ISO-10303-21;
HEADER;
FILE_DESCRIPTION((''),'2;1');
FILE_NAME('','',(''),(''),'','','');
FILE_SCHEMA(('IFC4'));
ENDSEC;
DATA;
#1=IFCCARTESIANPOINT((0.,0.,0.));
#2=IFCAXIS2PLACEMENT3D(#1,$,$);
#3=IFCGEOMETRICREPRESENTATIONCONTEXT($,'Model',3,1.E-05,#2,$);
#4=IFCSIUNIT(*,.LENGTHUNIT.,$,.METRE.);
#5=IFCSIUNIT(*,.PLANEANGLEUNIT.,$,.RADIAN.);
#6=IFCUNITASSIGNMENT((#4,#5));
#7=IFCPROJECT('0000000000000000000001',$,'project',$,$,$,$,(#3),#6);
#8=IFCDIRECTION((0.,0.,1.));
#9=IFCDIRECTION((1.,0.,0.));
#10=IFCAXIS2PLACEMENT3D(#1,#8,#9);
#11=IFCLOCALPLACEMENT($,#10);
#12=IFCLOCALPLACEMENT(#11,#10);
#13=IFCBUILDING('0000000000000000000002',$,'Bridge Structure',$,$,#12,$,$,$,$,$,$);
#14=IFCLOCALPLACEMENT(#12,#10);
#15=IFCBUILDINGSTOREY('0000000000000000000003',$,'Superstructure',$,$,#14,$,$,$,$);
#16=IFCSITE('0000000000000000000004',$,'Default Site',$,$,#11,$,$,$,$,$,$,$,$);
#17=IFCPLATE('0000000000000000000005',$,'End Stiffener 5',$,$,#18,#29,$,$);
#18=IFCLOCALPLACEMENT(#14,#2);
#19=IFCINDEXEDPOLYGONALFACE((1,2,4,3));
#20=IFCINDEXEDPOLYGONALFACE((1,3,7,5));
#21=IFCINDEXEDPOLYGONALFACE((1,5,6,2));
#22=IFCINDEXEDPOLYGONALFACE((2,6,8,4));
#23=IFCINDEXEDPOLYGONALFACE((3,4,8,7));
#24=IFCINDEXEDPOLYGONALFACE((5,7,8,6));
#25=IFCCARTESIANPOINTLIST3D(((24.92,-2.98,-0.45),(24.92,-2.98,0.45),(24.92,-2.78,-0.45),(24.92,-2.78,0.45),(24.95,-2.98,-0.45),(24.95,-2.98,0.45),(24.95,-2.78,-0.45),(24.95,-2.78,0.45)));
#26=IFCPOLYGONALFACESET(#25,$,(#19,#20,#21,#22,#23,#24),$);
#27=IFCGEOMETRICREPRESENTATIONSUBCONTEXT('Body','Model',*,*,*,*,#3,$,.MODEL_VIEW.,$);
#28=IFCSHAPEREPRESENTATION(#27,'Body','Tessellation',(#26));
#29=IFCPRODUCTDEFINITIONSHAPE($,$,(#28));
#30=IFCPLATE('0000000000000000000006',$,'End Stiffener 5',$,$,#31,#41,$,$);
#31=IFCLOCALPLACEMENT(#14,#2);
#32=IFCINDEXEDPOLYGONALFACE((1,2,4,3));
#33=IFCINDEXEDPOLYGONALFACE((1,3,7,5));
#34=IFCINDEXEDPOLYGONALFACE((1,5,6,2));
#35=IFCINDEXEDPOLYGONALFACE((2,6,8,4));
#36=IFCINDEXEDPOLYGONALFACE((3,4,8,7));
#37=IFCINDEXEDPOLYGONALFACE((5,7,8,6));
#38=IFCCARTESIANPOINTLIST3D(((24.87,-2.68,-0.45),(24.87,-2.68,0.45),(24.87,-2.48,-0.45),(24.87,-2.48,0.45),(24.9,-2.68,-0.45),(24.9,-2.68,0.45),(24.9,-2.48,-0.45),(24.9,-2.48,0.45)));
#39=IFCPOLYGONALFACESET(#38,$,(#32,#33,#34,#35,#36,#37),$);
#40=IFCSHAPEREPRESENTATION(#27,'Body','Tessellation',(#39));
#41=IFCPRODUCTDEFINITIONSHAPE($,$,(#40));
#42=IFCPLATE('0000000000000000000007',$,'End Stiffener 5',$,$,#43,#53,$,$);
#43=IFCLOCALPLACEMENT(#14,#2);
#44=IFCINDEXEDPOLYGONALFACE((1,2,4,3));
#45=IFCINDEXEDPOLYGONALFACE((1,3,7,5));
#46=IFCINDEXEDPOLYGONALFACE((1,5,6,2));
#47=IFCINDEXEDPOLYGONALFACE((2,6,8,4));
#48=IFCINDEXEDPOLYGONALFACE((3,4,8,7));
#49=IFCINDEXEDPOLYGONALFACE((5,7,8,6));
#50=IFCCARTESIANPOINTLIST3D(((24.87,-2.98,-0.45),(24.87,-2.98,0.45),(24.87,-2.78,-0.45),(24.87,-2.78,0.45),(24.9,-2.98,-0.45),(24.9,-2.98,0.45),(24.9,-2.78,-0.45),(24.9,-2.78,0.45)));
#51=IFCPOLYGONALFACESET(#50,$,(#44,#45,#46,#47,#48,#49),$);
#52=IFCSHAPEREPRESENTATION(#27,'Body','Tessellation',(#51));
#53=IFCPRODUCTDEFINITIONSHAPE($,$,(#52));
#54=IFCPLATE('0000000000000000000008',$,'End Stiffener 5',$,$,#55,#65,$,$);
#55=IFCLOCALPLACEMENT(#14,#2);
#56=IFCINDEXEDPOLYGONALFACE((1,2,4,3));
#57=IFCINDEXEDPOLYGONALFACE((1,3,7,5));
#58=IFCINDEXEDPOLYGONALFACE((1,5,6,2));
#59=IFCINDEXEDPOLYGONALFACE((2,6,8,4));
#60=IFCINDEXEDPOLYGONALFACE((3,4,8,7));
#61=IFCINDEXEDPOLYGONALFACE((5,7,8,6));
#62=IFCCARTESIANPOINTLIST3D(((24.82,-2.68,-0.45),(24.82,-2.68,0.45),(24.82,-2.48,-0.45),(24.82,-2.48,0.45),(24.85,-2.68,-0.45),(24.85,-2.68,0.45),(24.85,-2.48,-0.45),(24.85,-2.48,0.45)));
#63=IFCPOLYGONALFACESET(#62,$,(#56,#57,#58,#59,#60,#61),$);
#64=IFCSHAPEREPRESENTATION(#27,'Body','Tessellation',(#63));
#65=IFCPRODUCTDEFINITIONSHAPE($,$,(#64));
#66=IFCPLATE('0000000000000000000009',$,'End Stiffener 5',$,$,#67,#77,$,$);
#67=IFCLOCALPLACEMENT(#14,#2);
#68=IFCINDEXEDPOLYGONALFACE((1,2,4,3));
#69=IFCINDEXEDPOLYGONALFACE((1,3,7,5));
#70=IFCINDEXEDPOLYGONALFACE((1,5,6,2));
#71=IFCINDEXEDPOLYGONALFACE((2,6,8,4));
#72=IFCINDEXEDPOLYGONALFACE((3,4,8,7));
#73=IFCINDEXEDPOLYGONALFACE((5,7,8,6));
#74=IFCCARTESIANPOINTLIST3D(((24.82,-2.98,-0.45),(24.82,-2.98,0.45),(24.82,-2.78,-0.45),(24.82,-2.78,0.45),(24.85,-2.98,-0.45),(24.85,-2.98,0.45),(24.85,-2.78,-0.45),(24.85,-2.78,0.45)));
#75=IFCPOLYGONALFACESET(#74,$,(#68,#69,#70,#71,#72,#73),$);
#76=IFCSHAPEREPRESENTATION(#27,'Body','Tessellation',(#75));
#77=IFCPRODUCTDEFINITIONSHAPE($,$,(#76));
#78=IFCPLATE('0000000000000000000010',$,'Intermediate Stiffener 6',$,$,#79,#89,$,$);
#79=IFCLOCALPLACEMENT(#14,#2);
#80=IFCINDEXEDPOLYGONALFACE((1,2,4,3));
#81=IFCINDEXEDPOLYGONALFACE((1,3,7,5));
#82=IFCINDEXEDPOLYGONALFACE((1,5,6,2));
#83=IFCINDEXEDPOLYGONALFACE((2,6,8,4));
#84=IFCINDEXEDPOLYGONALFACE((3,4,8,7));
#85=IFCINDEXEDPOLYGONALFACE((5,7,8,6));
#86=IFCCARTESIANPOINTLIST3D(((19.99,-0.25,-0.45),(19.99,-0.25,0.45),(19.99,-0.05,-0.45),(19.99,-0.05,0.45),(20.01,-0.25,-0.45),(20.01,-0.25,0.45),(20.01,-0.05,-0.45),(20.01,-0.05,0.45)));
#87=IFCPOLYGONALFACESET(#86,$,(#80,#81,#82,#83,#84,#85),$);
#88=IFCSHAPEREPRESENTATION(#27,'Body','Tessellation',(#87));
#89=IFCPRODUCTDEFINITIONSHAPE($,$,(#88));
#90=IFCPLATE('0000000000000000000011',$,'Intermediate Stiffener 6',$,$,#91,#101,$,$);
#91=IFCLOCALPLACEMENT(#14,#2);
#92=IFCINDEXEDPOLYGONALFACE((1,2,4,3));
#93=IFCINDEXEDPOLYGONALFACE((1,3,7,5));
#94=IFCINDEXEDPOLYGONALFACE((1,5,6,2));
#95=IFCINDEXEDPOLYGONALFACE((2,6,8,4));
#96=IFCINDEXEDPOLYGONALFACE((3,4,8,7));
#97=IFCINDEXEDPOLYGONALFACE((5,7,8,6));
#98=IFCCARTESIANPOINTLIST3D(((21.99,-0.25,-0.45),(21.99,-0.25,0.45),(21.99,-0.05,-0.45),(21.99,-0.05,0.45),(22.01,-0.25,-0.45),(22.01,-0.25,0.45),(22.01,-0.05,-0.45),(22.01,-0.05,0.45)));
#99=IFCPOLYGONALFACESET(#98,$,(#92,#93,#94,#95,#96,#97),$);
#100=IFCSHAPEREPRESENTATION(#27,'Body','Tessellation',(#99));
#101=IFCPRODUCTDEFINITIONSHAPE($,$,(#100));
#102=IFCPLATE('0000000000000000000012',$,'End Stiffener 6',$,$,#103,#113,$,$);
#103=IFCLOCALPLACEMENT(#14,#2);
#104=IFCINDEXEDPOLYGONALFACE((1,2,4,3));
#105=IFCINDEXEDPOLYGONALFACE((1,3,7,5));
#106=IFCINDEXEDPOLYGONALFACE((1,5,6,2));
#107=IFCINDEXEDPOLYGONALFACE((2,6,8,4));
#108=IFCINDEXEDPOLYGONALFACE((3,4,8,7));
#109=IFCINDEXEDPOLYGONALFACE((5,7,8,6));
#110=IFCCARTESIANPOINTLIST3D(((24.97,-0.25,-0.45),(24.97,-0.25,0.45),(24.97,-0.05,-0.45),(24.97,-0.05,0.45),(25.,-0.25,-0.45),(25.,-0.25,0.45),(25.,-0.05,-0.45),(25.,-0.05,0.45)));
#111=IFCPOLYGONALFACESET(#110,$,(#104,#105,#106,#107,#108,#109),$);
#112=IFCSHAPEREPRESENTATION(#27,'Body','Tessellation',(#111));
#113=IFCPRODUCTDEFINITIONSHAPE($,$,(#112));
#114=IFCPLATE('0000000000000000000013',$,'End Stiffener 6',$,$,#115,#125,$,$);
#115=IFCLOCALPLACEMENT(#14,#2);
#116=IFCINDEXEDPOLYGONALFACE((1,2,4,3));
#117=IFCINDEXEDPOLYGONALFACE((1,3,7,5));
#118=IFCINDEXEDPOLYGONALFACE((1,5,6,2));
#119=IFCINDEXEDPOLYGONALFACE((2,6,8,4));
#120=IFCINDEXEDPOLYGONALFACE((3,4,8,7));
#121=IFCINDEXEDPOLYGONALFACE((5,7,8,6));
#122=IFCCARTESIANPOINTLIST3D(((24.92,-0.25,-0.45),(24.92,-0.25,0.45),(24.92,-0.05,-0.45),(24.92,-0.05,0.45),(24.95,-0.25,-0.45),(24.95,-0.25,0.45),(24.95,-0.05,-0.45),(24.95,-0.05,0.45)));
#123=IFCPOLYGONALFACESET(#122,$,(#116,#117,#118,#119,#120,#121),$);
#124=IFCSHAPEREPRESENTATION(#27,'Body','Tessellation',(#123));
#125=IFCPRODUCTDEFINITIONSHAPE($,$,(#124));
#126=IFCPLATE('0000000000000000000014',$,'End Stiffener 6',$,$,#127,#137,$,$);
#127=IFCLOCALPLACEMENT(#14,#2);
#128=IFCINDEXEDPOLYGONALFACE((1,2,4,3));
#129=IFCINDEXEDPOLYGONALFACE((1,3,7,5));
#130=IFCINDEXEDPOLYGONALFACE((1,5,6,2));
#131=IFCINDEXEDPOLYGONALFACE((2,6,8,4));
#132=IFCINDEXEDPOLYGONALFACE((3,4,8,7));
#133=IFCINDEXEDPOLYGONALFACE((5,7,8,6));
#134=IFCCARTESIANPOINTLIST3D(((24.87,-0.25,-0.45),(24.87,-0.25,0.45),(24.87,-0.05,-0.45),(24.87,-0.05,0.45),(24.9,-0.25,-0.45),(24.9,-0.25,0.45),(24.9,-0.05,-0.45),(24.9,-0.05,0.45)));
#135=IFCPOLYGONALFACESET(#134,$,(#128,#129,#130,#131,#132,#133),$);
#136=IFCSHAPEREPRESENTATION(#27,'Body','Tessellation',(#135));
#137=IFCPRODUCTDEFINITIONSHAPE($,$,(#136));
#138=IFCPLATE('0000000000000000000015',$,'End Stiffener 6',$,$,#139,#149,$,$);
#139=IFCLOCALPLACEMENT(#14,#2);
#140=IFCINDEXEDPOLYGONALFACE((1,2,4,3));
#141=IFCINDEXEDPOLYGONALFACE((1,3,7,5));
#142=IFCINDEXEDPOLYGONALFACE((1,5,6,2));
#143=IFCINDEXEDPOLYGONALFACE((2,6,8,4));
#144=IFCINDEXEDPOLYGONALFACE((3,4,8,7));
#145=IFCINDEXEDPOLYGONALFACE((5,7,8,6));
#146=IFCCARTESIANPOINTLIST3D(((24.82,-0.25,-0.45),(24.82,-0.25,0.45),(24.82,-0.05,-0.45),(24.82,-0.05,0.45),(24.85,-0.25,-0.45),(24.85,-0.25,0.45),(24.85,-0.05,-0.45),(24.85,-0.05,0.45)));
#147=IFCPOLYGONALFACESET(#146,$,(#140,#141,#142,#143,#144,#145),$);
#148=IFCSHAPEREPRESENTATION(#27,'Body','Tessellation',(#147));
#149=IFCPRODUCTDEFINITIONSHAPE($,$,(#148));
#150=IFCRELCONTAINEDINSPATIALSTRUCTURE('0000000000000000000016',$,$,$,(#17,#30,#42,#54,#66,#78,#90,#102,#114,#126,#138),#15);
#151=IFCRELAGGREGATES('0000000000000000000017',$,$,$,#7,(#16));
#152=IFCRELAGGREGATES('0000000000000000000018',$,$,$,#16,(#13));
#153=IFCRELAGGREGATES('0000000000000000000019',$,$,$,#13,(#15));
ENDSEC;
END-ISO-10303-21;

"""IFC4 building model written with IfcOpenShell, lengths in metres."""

from ifc_helpers import new_model, si_unit, frame, origin, origin_with_axes, origin_2d_with_axis, place, context, subcontext, project, spatial, rectangle, extrude, element, save


model = new_model("IFC4")

# Units and contexts
model_context = context("Model", 3, precision=1e-05, world=origin())
body_context = subcontext(model_context, "Body", "Model", "MODEL_VIEW")
ifc_project = project(units=[si_unit("LENGTHUNIT", "METRE"), si_unit("PLANEANGLEUNIT", "RADIAN")], contexts=[model_context])

# Site, building, storey
site_placement = place(None, origin_with_axes())
site = spatial("IfcSite", under=ifc_project, at=site_placement, Name="Default Site")
building_placement = place(site_placement, origin_with_axes())
building = spatial("IfcBuilding", under=site, at=building_placement, Name="Bridge Structure")
storey_placement = place(building_placement, origin_with_axes())
storey = spatial("IfcBuildingStorey", under=building, at=storey_placement, Name="Superstructure")

# Plates
for number, where, z_axis, x_axis, name in (
    (1, (24.935, -2.88, -0.45), (0.0, 0.0, 1.0), (1.0, 0.0, 0.0), "End Stiffener 5"),
    (2, (24.885, -2.58, -0.45), (0.0, 0.0, 1.0), (1.0, 0.0, 0.0), "End Stiffener 5"),
    (3, (24.885, -2.88, -0.45), (0.0, 0.0, 1.0), (1.0, 0.0, 0.0), "End Stiffener 5"),
    (4, (24.835, -2.58, -0.45), (0.0, 0.0, 1.0), (1.0, 0.0, 0.0), "End Stiffener 5"),
    (5, (24.835, -2.88, -0.45), (0.0, 0.0, 1.0), (1.0, 0.0, 0.0), "End Stiffener 5"),
):
    element("IfcPlate", number, at=place(storey_placement, frame(where, z_axis=z_axis, x_axis=x_axis)), inside=storey, Name=name, context=body_context, shape_type="SweptSolid", body=[
        extrude(rectangle(XDim=0.03, YDim=0.2, at=origin_2d_with_axis()), origin_with_axes(), (0.0, 0.0, 1.0), 0.9),
    ])
for number, where, z_axis, x_axis, name in (
    (6, (20.0, -0.15, -0.45), (0.0, 0.0, 1.0), (1.0, 0.0, 0.0), "Intermediate Stiffener 6"),
    (7, (22.0, -0.15, -0.45), (0.0, 0.0, 1.0), (1.0, 0.0, 0.0), "Intermediate Stiffener 6"),
):
    element("IfcPlate", number, at=place(storey_placement, frame(where, z_axis=z_axis, x_axis=x_axis)), inside=storey, Name=name, context=body_context, shape_type="SweptSolid", body=[
        extrude(rectangle(XDim=0.02, YDim=0.2, at=origin_2d_with_axis()), origin_with_axes(), (0.0, 0.0, 1.0), 0.9),
    ])
for number, where, z_axis, x_axis, name in (
    (8, (24.985, -0.15, -0.45), (0.0, 0.0, 1.0), (1.0, 0.0, 0.0), "End Stiffener 6"),
    (9, (24.935, -0.15, -0.45), (0.0, 0.0, 1.0), (1.0, 0.0, 0.0), "End Stiffener 6"),
    (10, (24.885, -0.15, -0.45), (0.0, 0.0, 1.0), (1.0, 0.0, 0.0), "End Stiffener 6"),
    (11, (24.835, -0.15, -0.45), (0.0, 0.0, 1.0), (1.0, 0.0, 0.0), "End Stiffener 6"),
):
    element("IfcPlate", number, at=place(storey_placement, frame(where, z_axis=z_axis, x_axis=x_axis)), inside=storey, Name=name, context=body_context, shape_type="SweptSolid", body=[
        extrude(rectangle(XDim=0.03, YDim=0.2, at=origin_2d_with_axis()), origin_with_axes(), (0.0, 0.0, 1.0), 0.9),
    ])

save(model, "model.ifc")
